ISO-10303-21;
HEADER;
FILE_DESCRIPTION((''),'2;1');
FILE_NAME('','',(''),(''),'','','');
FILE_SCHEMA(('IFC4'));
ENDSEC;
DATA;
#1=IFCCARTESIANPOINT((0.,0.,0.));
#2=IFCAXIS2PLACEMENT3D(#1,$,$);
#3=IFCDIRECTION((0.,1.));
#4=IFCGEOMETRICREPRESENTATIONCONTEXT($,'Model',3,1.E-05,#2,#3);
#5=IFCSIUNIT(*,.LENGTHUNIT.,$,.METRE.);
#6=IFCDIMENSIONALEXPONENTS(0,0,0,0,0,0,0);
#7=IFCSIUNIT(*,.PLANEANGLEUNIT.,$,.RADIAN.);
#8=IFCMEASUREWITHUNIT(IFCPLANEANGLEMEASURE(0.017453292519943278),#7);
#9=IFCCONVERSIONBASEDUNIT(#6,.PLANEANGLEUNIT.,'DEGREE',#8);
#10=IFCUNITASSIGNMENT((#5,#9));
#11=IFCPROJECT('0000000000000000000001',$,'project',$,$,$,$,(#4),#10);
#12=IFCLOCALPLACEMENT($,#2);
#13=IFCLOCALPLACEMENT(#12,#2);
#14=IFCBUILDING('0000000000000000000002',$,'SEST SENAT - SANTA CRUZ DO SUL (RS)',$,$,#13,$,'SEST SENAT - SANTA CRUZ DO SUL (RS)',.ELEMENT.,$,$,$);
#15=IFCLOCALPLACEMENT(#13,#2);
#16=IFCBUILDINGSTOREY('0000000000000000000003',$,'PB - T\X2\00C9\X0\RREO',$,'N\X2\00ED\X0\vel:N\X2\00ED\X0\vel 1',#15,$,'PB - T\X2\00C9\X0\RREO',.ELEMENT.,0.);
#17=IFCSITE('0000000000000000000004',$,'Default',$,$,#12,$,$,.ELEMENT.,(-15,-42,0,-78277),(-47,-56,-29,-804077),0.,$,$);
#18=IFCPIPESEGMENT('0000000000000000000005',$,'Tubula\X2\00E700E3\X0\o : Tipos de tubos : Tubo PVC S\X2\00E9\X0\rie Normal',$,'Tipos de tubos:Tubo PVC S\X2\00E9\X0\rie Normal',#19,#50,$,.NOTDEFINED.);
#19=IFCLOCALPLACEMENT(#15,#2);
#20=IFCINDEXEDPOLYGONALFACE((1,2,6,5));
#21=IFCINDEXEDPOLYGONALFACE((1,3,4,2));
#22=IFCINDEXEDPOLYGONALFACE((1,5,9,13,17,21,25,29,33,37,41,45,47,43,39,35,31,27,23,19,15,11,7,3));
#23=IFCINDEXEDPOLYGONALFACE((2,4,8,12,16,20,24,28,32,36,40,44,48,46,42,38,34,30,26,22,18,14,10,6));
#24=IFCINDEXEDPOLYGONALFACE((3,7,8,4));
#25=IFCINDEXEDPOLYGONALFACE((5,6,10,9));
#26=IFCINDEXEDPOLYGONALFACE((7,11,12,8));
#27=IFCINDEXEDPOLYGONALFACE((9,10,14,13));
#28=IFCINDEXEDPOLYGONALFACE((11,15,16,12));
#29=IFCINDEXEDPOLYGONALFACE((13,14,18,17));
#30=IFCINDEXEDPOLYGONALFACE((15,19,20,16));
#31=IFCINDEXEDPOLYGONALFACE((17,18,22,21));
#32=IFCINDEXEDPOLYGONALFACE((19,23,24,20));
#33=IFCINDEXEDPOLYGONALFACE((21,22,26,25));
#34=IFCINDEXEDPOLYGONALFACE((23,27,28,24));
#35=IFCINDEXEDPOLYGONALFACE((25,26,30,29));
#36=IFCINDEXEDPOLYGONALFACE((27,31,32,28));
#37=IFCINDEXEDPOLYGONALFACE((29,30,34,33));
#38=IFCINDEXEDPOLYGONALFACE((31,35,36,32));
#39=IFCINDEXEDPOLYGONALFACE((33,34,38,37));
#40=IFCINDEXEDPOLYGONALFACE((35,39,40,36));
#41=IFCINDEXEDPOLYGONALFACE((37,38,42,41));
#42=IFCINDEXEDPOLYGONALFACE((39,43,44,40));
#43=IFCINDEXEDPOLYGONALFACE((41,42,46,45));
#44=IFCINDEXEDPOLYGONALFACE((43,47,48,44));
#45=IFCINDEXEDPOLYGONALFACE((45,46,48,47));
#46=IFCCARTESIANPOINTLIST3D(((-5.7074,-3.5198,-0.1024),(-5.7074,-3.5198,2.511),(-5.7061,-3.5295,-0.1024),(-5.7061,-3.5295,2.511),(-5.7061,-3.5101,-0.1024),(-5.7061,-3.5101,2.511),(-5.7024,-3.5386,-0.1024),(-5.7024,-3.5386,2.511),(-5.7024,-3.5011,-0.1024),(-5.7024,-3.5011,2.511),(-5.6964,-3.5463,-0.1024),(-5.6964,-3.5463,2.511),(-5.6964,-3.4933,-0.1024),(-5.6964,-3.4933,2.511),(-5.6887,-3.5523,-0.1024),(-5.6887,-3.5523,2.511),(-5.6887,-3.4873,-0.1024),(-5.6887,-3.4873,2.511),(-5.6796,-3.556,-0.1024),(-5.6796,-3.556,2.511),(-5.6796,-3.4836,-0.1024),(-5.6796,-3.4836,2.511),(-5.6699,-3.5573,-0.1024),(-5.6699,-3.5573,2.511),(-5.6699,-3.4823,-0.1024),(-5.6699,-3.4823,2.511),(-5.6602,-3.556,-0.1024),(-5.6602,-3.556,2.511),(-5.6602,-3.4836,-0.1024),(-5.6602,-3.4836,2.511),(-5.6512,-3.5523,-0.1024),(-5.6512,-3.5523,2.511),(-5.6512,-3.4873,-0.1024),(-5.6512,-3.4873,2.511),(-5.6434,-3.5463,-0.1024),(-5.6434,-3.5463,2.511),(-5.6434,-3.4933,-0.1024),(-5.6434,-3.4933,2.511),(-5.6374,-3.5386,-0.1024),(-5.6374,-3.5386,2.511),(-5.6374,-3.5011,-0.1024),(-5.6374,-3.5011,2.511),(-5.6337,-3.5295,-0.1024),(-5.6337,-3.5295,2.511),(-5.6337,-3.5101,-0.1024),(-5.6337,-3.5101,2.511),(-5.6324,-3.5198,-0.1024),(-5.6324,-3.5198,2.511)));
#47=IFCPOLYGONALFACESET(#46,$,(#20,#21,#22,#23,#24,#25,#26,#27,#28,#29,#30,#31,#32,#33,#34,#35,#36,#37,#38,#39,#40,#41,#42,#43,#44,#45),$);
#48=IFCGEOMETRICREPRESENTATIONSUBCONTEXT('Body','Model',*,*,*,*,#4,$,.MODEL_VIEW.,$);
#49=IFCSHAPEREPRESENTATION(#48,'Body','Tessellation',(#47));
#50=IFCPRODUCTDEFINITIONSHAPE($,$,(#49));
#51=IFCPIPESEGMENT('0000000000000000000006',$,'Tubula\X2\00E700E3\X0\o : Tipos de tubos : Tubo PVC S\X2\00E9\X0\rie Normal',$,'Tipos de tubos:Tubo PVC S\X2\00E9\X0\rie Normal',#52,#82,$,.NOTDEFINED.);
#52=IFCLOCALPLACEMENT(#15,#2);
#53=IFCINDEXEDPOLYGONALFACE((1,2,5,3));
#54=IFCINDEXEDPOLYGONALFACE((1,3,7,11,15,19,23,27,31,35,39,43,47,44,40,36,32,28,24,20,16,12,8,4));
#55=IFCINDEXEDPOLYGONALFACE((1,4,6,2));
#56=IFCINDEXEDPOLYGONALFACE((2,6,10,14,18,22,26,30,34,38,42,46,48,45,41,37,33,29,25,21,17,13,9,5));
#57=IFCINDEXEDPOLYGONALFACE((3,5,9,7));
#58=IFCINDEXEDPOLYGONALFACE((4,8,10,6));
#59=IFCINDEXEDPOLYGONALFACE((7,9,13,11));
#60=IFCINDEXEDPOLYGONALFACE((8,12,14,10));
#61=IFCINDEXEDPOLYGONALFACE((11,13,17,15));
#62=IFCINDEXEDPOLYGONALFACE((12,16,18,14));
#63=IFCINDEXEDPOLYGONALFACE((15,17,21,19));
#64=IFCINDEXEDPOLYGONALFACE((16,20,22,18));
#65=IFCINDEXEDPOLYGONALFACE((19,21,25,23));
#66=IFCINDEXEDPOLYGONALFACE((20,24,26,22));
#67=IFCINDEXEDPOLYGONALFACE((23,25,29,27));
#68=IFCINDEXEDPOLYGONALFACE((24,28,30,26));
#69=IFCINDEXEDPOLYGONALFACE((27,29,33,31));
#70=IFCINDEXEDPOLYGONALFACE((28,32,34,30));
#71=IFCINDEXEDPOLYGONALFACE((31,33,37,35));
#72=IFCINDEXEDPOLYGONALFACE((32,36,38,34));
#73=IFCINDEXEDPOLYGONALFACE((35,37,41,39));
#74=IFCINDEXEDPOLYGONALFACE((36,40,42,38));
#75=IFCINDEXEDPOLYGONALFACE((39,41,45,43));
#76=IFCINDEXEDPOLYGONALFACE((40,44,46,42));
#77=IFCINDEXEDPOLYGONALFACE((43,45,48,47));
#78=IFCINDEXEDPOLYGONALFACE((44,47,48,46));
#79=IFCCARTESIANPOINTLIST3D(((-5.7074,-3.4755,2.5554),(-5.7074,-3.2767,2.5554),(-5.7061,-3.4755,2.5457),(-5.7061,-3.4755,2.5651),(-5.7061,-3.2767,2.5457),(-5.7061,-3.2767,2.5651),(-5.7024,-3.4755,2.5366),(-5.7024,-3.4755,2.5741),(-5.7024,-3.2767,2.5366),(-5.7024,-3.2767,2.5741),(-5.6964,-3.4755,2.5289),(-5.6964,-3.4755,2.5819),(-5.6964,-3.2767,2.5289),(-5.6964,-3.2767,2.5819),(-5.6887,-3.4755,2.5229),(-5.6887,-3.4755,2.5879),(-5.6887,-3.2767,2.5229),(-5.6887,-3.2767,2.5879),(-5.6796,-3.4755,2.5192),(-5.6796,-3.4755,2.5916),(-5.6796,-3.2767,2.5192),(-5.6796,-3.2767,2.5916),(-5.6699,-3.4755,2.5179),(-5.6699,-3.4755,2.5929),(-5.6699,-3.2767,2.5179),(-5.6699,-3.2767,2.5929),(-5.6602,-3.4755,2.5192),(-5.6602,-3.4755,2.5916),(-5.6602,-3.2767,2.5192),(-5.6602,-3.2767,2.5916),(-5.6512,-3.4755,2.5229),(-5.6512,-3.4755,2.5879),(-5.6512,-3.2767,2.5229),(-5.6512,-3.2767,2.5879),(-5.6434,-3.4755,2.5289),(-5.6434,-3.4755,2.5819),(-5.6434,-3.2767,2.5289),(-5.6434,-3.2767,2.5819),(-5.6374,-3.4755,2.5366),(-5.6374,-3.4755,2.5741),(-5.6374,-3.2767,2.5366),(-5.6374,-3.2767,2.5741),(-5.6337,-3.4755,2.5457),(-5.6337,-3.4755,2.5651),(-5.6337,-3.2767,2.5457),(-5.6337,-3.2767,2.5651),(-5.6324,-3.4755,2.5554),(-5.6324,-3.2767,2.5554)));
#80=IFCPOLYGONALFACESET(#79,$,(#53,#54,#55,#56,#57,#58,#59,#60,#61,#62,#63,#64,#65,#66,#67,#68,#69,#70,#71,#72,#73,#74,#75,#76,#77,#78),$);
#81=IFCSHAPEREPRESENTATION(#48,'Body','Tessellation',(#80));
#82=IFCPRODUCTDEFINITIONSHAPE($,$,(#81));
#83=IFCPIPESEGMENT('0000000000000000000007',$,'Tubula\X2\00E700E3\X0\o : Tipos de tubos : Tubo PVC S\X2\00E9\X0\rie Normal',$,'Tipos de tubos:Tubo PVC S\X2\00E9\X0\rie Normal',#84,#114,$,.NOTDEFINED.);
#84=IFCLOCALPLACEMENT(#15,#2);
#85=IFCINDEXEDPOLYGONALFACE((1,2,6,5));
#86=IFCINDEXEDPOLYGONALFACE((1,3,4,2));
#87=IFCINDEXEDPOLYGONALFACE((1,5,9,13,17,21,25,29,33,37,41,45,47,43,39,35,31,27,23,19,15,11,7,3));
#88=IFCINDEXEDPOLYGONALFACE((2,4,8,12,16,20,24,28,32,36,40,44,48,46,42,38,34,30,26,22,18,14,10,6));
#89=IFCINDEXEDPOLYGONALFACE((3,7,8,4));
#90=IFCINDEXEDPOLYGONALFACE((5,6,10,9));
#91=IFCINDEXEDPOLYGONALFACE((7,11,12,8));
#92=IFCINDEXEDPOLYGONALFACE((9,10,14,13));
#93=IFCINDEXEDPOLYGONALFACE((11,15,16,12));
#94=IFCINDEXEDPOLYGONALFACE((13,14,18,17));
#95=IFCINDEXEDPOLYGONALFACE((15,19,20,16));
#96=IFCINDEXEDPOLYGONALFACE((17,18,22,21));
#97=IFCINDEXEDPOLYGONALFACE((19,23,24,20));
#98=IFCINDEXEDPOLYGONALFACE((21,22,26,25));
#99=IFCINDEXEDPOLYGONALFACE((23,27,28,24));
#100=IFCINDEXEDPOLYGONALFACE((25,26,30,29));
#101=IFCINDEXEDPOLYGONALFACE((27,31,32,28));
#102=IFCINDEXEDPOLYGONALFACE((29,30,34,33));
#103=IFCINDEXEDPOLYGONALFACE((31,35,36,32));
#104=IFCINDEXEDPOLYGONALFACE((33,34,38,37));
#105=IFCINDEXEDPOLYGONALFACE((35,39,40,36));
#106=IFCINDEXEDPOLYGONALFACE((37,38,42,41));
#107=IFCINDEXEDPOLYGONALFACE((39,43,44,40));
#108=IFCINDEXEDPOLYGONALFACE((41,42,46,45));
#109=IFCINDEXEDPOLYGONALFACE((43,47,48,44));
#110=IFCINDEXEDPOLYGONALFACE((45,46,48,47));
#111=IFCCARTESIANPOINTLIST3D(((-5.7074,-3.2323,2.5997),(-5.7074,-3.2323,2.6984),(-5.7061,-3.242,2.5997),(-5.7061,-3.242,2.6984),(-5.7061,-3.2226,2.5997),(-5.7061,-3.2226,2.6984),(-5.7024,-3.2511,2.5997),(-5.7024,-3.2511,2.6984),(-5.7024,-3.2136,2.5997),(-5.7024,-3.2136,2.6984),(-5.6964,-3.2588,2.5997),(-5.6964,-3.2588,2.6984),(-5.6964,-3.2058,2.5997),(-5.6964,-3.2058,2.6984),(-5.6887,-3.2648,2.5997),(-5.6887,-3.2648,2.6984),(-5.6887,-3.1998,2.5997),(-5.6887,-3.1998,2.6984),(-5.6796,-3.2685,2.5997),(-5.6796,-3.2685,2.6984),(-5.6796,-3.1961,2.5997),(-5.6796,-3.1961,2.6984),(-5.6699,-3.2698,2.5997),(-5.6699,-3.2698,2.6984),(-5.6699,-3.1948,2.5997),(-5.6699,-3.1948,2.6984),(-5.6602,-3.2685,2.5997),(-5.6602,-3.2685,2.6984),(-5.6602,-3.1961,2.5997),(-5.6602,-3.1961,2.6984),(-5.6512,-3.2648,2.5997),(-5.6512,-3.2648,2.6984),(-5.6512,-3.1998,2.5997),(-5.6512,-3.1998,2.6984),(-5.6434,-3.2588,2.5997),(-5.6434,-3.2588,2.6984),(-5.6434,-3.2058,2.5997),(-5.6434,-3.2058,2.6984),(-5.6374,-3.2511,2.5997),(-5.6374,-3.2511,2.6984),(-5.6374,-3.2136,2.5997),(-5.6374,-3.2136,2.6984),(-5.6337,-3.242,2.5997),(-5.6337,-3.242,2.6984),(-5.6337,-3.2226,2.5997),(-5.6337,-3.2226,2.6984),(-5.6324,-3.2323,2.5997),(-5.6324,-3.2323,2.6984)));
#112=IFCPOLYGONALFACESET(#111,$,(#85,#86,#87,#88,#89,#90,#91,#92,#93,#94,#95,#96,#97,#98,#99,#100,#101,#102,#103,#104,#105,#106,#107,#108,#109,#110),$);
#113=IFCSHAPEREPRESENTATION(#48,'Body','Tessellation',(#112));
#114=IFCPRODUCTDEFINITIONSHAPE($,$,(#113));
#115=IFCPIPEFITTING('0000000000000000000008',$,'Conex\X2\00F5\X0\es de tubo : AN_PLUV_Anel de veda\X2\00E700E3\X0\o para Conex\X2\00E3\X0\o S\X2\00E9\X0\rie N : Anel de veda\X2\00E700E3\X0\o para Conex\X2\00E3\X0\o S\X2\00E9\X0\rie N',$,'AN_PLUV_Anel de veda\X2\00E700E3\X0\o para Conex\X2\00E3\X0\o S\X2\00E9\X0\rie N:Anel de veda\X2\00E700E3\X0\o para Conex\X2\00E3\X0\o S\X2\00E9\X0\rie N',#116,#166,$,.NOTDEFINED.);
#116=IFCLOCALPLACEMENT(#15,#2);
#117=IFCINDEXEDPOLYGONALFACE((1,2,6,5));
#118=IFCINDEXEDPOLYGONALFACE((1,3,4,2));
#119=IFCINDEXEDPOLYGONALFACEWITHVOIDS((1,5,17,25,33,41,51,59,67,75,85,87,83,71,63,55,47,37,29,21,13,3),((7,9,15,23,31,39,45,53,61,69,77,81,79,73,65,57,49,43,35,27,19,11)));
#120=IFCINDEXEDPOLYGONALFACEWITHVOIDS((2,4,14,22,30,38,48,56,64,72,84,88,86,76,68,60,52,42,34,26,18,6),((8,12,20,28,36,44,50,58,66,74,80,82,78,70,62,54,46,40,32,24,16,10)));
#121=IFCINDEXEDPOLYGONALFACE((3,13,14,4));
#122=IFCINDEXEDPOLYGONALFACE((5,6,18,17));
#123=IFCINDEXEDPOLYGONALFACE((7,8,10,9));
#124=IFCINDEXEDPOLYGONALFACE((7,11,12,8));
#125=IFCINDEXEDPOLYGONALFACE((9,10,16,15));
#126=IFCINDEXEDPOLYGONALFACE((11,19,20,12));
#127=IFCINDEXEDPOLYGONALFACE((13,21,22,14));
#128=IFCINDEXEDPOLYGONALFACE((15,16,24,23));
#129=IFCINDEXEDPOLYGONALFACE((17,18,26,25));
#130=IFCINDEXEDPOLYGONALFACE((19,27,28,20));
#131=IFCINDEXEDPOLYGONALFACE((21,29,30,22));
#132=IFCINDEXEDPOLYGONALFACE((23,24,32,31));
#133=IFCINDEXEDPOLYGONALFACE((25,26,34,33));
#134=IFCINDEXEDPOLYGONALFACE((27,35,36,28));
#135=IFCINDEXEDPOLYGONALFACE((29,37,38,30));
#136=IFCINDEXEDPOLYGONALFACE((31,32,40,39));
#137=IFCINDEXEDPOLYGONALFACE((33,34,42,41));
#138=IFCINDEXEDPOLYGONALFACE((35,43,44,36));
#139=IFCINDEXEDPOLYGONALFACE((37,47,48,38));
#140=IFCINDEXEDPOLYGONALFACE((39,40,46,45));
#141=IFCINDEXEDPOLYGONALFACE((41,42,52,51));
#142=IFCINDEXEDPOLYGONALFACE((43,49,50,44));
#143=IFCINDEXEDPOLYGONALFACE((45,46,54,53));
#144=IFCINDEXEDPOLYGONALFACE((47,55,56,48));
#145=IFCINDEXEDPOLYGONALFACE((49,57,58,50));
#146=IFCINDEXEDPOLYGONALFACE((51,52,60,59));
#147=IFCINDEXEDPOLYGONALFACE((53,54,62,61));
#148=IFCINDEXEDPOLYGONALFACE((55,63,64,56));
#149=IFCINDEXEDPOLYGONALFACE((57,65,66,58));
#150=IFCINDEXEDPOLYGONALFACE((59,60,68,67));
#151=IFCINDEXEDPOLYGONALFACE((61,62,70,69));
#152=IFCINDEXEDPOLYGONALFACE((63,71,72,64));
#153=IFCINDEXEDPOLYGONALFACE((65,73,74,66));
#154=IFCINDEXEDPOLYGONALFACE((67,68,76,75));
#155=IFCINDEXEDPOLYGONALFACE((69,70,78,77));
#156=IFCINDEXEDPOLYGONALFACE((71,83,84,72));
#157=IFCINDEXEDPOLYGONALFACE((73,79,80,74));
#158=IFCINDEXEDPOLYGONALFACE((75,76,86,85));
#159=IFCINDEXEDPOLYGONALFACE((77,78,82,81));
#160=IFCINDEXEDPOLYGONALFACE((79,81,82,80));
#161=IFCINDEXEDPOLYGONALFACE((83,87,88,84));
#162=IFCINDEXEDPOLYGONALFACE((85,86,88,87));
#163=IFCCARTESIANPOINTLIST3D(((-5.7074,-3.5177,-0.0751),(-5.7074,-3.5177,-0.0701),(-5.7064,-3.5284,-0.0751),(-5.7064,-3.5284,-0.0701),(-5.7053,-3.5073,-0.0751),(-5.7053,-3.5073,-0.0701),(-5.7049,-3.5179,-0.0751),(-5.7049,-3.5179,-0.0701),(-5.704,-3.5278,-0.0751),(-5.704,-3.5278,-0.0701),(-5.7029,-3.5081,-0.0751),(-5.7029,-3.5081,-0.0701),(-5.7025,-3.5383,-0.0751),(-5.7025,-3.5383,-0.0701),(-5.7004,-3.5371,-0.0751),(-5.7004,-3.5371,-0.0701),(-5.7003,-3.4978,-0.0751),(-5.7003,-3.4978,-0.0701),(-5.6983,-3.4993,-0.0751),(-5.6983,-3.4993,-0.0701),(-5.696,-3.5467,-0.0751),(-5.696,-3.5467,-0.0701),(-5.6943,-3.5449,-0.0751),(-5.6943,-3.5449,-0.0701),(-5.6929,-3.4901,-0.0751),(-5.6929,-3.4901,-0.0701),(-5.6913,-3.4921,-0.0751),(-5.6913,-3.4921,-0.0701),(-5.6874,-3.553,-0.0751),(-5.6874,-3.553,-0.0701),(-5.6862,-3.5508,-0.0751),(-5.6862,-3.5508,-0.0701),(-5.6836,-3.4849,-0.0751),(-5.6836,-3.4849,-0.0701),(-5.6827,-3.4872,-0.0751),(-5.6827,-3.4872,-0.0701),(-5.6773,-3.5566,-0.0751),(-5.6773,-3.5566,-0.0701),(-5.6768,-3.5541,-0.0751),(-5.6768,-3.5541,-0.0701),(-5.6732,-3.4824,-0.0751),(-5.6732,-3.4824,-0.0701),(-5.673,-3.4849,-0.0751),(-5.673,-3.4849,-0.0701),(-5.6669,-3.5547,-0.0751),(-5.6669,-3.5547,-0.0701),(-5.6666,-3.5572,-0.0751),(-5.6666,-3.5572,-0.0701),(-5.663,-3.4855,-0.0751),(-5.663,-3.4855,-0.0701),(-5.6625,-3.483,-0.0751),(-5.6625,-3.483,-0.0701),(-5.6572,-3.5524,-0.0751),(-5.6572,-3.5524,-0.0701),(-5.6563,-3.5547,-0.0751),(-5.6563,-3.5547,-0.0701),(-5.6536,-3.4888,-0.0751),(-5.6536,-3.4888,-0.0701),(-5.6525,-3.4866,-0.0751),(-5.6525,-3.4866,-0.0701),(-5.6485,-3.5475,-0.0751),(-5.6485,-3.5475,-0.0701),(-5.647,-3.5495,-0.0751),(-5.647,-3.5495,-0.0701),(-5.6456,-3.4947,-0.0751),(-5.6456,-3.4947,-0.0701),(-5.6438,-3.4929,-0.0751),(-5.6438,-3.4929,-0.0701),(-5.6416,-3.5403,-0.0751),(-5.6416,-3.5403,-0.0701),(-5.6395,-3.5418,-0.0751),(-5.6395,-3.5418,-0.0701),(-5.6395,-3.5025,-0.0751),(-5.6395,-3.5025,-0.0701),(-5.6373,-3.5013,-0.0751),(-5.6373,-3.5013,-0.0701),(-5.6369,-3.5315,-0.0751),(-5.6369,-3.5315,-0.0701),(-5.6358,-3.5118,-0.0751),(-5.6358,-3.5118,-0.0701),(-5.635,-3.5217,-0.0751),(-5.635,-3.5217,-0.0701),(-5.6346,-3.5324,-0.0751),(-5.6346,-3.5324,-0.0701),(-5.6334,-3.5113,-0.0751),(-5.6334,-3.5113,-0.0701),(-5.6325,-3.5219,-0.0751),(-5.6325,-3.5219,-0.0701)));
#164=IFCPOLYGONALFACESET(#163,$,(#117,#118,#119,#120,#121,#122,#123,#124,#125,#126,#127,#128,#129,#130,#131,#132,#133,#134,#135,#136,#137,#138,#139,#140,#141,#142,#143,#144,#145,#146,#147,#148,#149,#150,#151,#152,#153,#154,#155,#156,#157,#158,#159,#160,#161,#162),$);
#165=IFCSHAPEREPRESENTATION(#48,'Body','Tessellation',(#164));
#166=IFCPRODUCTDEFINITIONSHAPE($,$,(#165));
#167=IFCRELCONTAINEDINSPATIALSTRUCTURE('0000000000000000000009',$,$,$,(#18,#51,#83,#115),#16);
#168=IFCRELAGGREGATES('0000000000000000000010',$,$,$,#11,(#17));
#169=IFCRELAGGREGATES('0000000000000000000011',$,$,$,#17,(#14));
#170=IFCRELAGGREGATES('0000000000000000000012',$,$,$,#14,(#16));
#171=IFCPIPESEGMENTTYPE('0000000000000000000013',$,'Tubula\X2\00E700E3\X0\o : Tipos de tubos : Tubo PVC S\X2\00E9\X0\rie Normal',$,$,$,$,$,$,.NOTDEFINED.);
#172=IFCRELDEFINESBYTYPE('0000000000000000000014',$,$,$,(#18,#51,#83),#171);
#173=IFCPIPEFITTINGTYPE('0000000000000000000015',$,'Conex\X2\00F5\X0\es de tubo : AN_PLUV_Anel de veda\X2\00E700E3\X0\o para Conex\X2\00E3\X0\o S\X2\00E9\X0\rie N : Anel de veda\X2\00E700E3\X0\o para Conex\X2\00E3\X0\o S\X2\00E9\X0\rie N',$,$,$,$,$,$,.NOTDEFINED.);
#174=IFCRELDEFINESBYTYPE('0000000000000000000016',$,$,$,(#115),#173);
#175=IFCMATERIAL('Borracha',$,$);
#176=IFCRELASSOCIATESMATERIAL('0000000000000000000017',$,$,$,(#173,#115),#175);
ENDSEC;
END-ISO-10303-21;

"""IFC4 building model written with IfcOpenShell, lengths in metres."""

from ifc_helpers import new_model, entity, si_unit, converted_unit, direction, frame, origin, place, context, subcontext, project, spatial, arc, indexed_curve, outline, extrude, source, transform, mapped, material, type_object, type_shapes, element, save


model = new_model("IFC4")

# Units and contexts
model_context = context("Model", 3, precision=1e-05, world=origin(), true_north=direction((0.0, 1.0)))
body_context = subcontext(model_context, "Body", "Model", "MODEL_VIEW")
ifc_project = project(units=[si_unit("LENGTHUNIT", "METRE"), converted_unit("PLANEANGLEUNIT", "DEGREE", entity("IfcPlaneAngleMeasure", 0.017453292519943278), si_unit("PLANEANGLEUNIT", "RADIAN"), dimensions=[0, 0, 0, 0, 0, 0, 0])], contexts=[model_context])

# Site, building, storey
site_placement = place(None, origin())
site = spatial("IfcSite", under=ifc_project, at=site_placement, Name="Default", CompositionType="ELEMENT", RefLatitude=(-15, -42, 0, -78277), RefLongitude=(-47, -56, -29, -804077), RefElevation=0.0)
building_placement = place(site_placement, origin())
building = spatial("IfcBuilding", under=site, at=building_placement, Name="SEST SENAT - SANTA CRUZ DO SUL (RS)", LongName="SEST SENAT - SANTA CRUZ DO SUL (RS)", CompositionType="ELEMENT")
storey_placement = place(building_placement, origin())
storey = spatial("IfcBuildingStorey", under=building, at=storey_placement, Name="PB - TÉRREO", ObjectType="Nível:Nível 1", LongName="PB - TÉRREO", CompositionType="ELEMENT", Elevation=0.0)

# Shared definitions
ifc_material_1 = material(Name="Borracha")

# Pipe segments
pipe_segment_type_1 = type_object("IfcPipeSegmentType", Name="Tubulação : Tipos de tubos : Tubo PVC Série Normal", PredefinedType="NOTDEFINED")
pipe_segment_1_placement = place(storey_placement, frame((-5.709, -3.5589, -0.1024)))
element("IfcPipeSegment", 1, at=pipe_segment_1_placement, inside=storey, type_object=pipe_segment_type_1, Name="Tubulação : Tipos de tubos : Tubo PVC Série Normal", ObjectType="Tipos de tubos:Tubo PVC Série Normal", PredefinedType="NOTDEFINED", context=body_context, shape_type="SweptSolid", body=[
    extrude(outline(indexed_curve([(0.0375, 0.0), (0.0265, 0.0265), (0.0, 0.0375), (-0.0265, 0.0265), (-0.0375, 0.0), (-0.0265, -0.0265), (0.0, -0.0375), (0.0265, -0.0265)], segments=[arc(1, 2, 3), arc(3, 4, 5), arc(5, 6, 7), arc(7, 8, 1)], self_intersect=False)), frame((0.0391, 0.0391, 0.0)), (0.0, 0.0, 1.0), 2.6134),
])
pipe_segment_2_placement = place(storey_placement, frame((-5.709, -3.4755, 2.5163)))
element("IfcPipeSegment", 2, at=pipe_segment_2_placement, inside=storey, type_object=pipe_segment_type_1, Name="Tubulação : Tipos de tubos : Tubo PVC Série Normal", ObjectType="Tipos de tubos:Tubo PVC Série Normal", PredefinedType="NOTDEFINED", context=body_context, shape_type="SweptSolid", body=[
    extrude(outline(indexed_curve([(0.0375, 0.0), (0.0265, 0.0265), (0.0, 0.0375), (-0.0265, 0.0265), (-0.0375, 0.0), (-0.0265, -0.0265), (0.0, -0.0375), (0.0265, -0.0265)], segments=[arc(1, 2, 3), arc(3, 4, 5), arc(5, 6, 7), arc(7, 8, 1)], self_intersect=False)), frame((0.0391, 0.0, 0.0391), z_axis=(0.0, 1.0, 0.0), x_axis=(1.0, 0.0, 0.0)), (0.0, 0.0, 1.0), 0.1988),
])
pipe_segment_3_placement = place(storey_placement, frame((-5.709, -3.2714, 2.6984)))
element("IfcPipeSegment", 3, at=pipe_segment_3_placement, inside=storey, type_object=pipe_segment_type_1, Name="Tubulação : Tipos de tubos : Tubo PVC Série Normal", ObjectType="Tipos de tubos:Tubo PVC Série Normal", PredefinedType="NOTDEFINED", context=body_context, shape_type="SweptSolid", body=[
    extrude(outline(indexed_curve([(0.0375, 0.0), (0.0265, 0.0265), (0.0, 0.0375), (-0.0265, 0.0265), (-0.0375, 0.0), (-0.0265, -0.0265), (0.0, -0.0375), (0.0265, -0.0265)], segments=[arc(1, 2, 3), arc(3, 4, 5), arc(5, 6, 7), arc(7, 8, 1)], self_intersect=False)), frame((0.0391, 0.0391, -0.0986), z_axis=(0.0, 0.0, 1.0), x_axis=(-1.0, 0.0, 0.0)), (0.0, 0.0, 1.0), 0.0986),
])

# Pipe fitting
pipe_fitting_type_1 = type_object("IfcPipeFittingType", Name="Conexões de tubo : AN_PLUV_Anel de vedação para Conexão Série N : Anel de vedação para Conexão Série N", PredefinedType="NOTDEFINED", material=ifc_material_1)
shared_shape_1 = source(origin(), body_context, "Body", "SweptSolid", [
    extrude(outline(indexed_curve([(-0.0375, 0.0), (0.0, -0.0375), (0.0375, 0.0), (0.0, 0.0375)], segments=[arc(1, 2, 3), arc(3, 4, 1)], self_intersect=False), holes=[indexed_curve([(-0.035, 0.0), (0.0, 0.035), (0.035, 0.0), (0.0, -0.035)], segments=[arc(1, 2, 3), arc(3, 4, 1)], self_intersect=False)]), frame((0.0, 0.0, -0.005)), (0.0, 0.0, 1.0), 0.005),
])
type_shapes(pipe_fitting_type_1, [shared_shape_1])
for number, where, z_axis, x_axis, name in (
    (4, (-5.6699, -3.5198, -0.0701), (0.0, 0.0, 1.0), (0.08716, -0.996194, 0.0), "Conexões de tubo : AN_PLUV_Anel de vedação para Conexão Série N : Anel de vedação para Conexão Série N"),
):
    element("IfcPipeFitting", number, at=place(storey_placement, frame(where, z_axis=z_axis, x_axis=x_axis)), inside=storey, type_object=pipe_fitting_type_1, material=ifc_material_1, Name=name, ObjectType="AN_PLUV_Anel de vedação para Conexão Série N:Anel de vedação para Conexão Série N", PredefinedType="NOTDEFINED", context=body_context, shape_type="MappedRepresentation", body=[
        mapped(shared_shape_1, transform((0.0, 0.0, 0.0), scale=1.0)),
    ])

save(model, "model.ifc")
